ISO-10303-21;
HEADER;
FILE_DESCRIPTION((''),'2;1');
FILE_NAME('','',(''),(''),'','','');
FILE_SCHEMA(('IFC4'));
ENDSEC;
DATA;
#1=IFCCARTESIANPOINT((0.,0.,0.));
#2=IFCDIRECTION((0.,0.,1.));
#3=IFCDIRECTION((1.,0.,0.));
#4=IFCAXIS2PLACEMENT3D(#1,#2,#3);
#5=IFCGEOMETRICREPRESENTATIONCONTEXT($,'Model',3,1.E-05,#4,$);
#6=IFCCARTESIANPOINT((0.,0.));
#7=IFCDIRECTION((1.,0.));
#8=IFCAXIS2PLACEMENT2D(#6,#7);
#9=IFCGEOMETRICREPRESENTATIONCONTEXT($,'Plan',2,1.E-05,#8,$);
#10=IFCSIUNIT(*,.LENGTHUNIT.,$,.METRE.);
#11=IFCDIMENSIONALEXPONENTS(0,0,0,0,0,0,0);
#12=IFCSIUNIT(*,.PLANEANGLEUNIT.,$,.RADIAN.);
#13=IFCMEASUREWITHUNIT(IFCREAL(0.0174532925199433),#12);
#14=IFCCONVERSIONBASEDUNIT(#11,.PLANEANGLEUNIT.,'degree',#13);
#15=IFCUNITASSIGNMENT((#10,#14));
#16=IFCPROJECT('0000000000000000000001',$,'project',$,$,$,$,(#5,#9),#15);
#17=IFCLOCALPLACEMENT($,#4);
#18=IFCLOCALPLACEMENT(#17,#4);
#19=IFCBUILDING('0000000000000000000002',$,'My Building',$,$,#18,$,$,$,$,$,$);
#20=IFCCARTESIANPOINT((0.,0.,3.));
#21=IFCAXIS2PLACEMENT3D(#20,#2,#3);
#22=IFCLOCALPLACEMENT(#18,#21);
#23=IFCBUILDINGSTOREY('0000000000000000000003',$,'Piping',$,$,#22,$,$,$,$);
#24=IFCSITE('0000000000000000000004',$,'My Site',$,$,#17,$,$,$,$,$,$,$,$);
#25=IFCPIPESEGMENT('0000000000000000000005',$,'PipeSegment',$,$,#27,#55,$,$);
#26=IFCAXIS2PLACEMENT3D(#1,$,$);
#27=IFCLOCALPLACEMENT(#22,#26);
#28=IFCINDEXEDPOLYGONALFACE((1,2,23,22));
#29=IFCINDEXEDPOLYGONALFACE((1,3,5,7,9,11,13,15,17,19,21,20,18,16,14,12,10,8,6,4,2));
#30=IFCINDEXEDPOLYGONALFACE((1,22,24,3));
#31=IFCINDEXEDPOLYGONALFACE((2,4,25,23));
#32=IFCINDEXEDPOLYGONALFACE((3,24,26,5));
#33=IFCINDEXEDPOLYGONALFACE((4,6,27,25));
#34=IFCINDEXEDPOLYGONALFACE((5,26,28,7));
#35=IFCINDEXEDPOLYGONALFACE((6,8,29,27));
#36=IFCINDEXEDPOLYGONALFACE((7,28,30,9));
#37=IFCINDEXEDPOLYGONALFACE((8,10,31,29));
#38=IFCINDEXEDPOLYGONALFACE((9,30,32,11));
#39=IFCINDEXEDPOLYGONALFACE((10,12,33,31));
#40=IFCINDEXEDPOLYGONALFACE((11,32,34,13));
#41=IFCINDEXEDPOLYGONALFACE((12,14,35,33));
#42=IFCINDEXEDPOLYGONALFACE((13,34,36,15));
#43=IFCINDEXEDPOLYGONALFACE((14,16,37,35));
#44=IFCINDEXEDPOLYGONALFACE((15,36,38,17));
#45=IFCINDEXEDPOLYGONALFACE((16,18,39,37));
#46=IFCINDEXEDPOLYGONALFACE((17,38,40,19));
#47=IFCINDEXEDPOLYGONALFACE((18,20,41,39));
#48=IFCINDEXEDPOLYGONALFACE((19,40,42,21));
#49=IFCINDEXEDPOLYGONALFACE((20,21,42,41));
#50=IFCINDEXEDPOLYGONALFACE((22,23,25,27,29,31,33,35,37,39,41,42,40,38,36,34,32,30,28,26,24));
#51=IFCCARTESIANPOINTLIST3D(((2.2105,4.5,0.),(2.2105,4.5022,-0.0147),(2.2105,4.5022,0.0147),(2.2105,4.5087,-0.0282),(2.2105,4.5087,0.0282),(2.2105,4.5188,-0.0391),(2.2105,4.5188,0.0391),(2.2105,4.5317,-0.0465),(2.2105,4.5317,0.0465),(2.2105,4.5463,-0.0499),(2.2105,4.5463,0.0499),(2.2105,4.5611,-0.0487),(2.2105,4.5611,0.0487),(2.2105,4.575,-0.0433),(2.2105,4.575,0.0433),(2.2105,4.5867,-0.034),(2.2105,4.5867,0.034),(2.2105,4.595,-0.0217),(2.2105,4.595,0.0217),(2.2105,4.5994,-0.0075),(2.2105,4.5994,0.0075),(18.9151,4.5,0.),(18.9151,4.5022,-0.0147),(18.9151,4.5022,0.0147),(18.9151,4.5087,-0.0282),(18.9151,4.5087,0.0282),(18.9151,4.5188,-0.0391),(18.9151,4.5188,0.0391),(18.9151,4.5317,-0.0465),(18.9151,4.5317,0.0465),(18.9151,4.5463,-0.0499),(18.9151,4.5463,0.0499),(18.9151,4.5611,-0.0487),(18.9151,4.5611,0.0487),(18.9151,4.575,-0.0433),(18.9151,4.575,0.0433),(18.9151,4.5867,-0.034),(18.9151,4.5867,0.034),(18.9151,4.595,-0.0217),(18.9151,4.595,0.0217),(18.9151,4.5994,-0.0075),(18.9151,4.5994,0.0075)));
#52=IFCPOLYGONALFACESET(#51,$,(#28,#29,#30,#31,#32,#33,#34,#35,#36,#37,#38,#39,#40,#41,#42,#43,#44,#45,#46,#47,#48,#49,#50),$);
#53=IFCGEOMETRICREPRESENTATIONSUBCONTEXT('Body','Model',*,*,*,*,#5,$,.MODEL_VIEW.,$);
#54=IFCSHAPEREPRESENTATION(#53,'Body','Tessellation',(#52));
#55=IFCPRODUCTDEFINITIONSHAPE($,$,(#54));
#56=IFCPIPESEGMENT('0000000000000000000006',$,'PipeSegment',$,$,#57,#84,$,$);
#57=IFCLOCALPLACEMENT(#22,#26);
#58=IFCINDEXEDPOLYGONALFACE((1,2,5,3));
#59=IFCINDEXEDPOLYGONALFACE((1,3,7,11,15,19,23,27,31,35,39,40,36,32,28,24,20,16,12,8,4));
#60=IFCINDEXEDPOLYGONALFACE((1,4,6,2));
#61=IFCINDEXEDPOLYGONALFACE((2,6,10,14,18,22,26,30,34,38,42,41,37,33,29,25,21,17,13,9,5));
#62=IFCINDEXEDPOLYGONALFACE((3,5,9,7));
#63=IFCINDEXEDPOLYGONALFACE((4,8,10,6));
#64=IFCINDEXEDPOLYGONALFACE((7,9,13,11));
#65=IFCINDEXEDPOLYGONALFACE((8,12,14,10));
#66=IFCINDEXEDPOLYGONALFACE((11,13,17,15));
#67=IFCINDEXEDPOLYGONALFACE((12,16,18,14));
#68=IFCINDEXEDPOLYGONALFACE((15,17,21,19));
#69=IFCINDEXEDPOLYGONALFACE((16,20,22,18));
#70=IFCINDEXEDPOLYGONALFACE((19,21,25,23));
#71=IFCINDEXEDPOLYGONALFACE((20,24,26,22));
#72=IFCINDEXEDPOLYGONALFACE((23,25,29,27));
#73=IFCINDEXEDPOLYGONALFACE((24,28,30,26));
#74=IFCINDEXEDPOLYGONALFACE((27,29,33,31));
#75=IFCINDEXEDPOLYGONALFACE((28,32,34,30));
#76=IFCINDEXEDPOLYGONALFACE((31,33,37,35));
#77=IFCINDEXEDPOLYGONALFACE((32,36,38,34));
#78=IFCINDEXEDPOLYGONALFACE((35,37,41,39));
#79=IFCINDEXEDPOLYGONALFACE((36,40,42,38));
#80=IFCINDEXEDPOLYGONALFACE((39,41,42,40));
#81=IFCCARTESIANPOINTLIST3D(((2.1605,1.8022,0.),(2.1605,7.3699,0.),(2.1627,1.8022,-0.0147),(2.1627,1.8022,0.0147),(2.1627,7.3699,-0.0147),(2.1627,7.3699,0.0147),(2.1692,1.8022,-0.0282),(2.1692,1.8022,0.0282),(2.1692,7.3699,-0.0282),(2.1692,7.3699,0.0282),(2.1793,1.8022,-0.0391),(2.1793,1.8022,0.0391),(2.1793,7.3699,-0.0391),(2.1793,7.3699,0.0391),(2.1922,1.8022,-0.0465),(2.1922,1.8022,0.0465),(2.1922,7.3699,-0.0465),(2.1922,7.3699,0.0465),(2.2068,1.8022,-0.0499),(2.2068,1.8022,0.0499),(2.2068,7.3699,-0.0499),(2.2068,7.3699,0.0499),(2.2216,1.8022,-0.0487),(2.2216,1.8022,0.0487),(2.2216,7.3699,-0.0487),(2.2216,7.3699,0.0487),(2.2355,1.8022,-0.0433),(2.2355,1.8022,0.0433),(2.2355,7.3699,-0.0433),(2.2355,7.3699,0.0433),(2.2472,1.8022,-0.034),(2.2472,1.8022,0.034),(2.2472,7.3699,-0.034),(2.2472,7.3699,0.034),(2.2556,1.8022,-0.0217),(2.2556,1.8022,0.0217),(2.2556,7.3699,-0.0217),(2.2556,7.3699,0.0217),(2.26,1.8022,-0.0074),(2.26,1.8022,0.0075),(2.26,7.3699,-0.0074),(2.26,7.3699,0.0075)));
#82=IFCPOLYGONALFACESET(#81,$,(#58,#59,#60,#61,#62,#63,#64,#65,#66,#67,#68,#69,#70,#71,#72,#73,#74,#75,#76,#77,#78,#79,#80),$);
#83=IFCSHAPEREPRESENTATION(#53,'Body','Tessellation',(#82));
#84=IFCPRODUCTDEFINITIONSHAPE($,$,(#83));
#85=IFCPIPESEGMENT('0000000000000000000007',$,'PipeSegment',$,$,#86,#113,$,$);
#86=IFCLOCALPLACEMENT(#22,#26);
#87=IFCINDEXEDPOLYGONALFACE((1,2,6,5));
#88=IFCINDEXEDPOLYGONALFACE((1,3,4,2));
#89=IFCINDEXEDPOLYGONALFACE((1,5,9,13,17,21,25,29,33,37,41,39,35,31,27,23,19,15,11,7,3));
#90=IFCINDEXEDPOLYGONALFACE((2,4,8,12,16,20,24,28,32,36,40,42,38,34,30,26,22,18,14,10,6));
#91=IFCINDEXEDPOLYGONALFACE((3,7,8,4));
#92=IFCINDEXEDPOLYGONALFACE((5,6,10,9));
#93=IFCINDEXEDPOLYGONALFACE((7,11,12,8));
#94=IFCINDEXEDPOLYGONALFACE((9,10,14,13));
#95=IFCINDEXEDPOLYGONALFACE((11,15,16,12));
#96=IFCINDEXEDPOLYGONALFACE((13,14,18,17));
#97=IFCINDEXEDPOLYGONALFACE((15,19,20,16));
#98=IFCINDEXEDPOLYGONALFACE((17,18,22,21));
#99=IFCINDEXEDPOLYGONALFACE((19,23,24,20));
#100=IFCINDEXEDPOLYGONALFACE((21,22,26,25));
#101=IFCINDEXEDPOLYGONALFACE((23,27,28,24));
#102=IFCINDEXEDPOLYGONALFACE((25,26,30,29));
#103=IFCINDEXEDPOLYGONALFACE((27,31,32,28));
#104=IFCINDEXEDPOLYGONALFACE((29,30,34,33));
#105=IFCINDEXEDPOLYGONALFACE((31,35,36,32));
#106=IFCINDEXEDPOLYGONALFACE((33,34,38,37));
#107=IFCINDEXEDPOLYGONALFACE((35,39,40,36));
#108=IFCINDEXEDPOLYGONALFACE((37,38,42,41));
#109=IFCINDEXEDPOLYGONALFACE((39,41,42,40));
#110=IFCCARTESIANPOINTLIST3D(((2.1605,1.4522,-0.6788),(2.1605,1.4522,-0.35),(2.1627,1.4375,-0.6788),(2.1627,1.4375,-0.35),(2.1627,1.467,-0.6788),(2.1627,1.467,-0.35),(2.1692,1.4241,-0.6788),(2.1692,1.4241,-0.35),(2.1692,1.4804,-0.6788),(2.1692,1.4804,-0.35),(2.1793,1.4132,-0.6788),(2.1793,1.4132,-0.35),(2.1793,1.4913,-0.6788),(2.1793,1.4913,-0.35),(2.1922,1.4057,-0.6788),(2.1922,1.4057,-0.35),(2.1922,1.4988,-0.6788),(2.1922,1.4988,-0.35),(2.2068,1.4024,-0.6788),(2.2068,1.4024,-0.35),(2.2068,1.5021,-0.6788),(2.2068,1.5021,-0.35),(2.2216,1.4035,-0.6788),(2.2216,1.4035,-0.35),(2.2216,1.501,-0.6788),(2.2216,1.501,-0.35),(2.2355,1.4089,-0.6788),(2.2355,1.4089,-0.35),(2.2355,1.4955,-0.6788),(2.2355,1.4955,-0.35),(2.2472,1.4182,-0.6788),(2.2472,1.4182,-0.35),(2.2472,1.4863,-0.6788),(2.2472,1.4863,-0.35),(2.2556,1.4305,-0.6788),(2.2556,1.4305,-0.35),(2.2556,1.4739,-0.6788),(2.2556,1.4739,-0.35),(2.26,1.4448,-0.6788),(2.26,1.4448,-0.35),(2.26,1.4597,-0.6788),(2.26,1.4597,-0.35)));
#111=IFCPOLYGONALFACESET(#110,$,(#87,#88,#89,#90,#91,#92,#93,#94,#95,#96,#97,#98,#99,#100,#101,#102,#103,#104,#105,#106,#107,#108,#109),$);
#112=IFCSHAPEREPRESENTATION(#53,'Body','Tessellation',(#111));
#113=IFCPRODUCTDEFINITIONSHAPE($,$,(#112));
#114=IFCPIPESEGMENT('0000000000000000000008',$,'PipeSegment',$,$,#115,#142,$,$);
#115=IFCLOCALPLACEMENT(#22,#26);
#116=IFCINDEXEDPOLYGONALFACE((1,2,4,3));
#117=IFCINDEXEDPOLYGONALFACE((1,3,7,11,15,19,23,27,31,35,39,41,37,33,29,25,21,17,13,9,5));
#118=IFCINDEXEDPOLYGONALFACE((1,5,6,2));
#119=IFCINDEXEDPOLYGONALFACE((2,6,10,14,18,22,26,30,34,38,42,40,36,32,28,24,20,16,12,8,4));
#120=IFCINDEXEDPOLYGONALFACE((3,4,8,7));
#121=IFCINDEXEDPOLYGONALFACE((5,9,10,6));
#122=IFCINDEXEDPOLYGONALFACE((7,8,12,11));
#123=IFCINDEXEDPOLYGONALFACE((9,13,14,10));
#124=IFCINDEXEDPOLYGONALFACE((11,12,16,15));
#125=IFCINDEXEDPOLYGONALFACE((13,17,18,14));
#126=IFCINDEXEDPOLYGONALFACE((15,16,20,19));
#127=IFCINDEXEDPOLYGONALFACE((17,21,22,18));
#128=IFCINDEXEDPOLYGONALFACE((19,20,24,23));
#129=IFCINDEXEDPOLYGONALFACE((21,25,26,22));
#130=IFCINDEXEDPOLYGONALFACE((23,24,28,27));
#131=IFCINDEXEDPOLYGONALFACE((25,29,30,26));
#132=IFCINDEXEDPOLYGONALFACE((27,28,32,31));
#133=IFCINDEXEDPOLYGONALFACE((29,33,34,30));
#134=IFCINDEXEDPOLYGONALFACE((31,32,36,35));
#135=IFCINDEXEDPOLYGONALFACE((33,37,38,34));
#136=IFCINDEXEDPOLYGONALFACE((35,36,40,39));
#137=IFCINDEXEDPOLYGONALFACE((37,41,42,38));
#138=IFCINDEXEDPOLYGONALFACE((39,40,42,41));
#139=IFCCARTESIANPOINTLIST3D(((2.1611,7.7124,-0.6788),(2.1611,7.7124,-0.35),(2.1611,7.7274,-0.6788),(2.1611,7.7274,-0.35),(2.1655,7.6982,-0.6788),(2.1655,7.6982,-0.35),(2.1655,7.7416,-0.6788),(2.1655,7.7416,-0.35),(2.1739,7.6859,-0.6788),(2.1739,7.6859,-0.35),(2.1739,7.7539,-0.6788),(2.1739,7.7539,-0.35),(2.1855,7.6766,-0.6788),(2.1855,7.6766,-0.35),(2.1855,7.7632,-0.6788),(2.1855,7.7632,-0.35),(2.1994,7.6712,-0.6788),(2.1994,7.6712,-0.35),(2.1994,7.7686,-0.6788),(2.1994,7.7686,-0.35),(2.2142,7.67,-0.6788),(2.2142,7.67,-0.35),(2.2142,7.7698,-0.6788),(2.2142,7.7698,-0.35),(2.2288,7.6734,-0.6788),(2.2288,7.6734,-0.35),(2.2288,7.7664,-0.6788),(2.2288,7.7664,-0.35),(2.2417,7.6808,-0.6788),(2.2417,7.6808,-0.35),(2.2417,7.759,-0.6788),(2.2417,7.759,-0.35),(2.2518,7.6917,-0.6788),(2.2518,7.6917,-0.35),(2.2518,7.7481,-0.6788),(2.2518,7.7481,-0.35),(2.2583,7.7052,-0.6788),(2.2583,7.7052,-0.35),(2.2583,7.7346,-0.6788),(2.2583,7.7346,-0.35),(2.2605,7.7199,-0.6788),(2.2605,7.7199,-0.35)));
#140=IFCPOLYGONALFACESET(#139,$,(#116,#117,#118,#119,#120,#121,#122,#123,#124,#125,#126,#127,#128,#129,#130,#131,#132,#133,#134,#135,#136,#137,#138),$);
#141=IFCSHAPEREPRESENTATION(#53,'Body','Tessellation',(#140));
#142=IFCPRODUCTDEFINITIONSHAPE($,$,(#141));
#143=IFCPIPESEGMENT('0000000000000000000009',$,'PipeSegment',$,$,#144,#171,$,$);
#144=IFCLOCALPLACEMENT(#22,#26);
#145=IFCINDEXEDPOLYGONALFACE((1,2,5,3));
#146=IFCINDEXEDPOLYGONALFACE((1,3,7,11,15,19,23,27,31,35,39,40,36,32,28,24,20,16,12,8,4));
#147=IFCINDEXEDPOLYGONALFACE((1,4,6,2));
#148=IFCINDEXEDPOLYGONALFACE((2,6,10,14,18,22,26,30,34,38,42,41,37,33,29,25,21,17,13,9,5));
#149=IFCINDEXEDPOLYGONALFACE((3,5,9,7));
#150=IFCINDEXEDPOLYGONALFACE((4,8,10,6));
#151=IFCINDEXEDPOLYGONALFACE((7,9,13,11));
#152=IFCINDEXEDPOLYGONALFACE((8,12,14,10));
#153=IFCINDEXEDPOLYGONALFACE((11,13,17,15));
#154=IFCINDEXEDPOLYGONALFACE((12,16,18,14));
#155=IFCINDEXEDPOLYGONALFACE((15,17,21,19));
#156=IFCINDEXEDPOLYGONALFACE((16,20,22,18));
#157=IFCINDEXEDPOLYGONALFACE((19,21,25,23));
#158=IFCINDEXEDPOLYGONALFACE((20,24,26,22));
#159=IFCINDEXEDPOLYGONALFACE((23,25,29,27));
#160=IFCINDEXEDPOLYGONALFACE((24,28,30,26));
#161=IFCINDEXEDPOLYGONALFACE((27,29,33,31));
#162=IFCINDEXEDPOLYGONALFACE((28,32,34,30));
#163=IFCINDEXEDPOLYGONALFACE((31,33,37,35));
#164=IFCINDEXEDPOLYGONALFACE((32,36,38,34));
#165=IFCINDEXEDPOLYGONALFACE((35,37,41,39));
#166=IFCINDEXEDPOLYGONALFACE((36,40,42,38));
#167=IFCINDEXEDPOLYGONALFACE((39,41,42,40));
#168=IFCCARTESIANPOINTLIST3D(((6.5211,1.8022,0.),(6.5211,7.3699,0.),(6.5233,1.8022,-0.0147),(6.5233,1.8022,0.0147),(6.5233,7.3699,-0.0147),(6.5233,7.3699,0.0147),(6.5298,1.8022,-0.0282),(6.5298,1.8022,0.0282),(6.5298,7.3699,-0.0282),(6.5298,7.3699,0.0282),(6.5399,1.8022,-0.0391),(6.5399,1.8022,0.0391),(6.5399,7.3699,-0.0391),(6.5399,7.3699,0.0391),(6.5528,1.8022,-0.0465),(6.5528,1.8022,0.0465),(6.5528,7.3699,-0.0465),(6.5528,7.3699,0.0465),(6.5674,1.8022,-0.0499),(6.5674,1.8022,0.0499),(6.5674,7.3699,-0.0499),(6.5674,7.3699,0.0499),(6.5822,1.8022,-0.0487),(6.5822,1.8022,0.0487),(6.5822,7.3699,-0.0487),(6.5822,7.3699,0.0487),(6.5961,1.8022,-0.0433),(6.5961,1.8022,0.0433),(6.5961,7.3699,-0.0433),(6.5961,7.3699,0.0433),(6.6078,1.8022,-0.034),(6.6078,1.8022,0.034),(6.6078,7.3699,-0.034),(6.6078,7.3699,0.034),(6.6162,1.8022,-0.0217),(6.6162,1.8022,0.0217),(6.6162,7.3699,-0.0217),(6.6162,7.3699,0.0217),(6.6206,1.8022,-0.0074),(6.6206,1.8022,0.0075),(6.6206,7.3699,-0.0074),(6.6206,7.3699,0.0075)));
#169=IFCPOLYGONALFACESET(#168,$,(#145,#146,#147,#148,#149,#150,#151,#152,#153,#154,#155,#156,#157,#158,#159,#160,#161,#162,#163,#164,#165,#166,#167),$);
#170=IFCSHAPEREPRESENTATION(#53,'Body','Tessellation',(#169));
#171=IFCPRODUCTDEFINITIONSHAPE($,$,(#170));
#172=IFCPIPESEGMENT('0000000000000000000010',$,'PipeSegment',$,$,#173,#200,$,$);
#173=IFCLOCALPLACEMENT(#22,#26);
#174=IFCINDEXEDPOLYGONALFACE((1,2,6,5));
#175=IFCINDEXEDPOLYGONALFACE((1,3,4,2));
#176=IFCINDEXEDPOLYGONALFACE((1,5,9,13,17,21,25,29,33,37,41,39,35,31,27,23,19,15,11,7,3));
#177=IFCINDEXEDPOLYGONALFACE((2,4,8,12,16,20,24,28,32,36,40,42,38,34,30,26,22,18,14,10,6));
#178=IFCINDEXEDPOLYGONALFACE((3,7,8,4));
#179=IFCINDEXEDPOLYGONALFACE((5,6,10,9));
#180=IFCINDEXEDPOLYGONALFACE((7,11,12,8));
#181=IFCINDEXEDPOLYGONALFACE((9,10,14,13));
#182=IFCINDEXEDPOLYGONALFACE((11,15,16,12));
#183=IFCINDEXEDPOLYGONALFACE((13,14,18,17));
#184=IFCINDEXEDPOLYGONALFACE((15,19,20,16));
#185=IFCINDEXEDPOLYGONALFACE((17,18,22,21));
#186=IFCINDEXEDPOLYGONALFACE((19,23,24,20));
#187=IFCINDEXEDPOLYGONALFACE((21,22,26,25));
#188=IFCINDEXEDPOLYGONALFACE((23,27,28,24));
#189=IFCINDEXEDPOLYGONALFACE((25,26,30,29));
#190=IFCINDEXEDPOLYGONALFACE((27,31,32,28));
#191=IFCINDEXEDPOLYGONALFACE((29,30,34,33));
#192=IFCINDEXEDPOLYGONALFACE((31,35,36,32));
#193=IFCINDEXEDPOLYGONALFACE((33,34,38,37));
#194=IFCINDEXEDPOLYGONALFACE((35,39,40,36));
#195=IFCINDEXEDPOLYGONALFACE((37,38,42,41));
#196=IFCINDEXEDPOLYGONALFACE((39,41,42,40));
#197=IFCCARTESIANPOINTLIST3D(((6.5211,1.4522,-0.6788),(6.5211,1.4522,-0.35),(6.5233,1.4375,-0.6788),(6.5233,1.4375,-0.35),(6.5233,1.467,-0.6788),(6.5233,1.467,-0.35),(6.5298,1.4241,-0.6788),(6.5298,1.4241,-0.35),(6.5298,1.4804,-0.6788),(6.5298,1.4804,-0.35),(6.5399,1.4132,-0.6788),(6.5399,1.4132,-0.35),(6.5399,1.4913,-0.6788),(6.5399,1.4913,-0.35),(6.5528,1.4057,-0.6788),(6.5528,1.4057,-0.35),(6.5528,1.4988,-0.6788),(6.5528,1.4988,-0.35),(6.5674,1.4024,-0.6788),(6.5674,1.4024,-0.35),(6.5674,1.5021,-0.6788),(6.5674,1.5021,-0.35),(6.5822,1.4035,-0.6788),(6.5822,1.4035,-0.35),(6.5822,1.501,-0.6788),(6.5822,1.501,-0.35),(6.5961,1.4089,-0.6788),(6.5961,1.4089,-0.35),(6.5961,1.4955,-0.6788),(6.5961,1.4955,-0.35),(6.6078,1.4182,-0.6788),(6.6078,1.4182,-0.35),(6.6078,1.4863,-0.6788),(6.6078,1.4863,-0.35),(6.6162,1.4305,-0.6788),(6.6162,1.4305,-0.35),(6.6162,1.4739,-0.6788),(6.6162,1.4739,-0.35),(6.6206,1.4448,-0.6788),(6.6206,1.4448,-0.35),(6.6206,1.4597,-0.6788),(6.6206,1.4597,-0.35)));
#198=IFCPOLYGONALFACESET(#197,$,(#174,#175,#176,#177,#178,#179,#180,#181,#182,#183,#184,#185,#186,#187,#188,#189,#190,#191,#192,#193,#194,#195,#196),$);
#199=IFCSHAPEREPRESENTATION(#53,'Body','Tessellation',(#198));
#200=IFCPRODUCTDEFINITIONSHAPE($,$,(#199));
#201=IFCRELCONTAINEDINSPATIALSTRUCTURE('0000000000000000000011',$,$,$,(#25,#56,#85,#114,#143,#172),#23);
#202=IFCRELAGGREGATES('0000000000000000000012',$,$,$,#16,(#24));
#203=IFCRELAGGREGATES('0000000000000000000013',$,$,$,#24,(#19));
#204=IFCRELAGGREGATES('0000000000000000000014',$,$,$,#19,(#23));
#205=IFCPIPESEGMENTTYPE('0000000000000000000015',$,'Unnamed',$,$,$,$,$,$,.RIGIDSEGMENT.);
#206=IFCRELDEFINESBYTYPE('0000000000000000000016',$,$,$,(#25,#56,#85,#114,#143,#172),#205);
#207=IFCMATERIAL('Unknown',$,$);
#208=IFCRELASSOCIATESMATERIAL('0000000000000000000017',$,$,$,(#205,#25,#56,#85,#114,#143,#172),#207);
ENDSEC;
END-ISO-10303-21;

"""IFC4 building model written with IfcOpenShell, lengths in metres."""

from ifc_helpers import new_model, entity, si_unit, converted_unit, frame, origin_with_axes, origin_2d_with_axis, place, context, subcontext, project, spatial, circle, extrude, material, material_profile, profile_set, profile_usage, type_object, element, save


model = new_model("IFC4")

# Units and contexts
model_context = context("Model", 3, precision=1e-05, world=origin_with_axes())
plan_context = context("Plan", 2, precision=1e-05, world=origin_2d_with_axis())
body_context = subcontext(model_context, "Body", "Model", "MODEL_VIEW")
ifc_project = project(units=[si_unit("LENGTHUNIT", "METRE"), converted_unit("PLANEANGLEUNIT", "degree", entity("IfcReal", 0.0174532925199433), si_unit("PLANEANGLEUNIT", "RADIAN"), dimensions=[0, 0, 0, 0, 0, 0, 0])], contexts=[model_context, plan_context])

# Site, building, storey
site_placement = place(None, origin_with_axes())
site = spatial("IfcSite", under=ifc_project, at=site_placement, Name="My Site")
building_placement = place(site_placement, origin_with_axes())
building = spatial("IfcBuilding", under=site, at=building_placement, Name="My Building")
storey_placement = place(building_placement, frame((0.0, 0.0, 3.0), z_axis=(0.0, 0.0, 1.0), x_axis=(1.0, 0.0, 0.0)))
storey = spatial("IfcBuildingStorey", under=building, at=storey_placement, Name="Piping")

# Pipe segments
ifc_material = material(Name="Unknown")
ifc_material_profile = material_profile(ifc_material, circle(Radius=0.05))
ifc_profile_set = profile_set([ifc_material_profile])
ifc_profile_usage_1 = profile_usage(ifc_profile_set, cardinal=5)
pipe_segment_type = type_object("IfcPipeSegmentType", Name="Unnamed", PredefinedType="RIGIDSEGMENT", material=ifc_profile_set)
pipe_segment_1_placement = place(storey_placement, frame((18.9151, 4.55, 0.0), z_axis=(-1.0, 0.0, 0.0), x_axis=(0.0, -1.0, 0.0)))
element("IfcPipeSegment", 1, at=pipe_segment_1_placement, inside=storey, type_object=pipe_segment_type, material=ifc_profile_usage_1, Name="PipeSegment", context=body_context, shape_type="SweptSolid", body=[
    extrude(circle(Radius=0.05), origin_with_axes(), (0.0, 0.0, 1.0), 16.7046),
])
ifc_profile_usage_2 = profile_usage(ifc_profile_set, cardinal=5)
pipe_segment_2_placement = place(storey_placement, frame((2.2105, 1.8022, 0.0), z_axis=(0.0, 1.0, 0.0), x_axis=(-1.0, 0.0, 0.0)))
element("IfcPipeSegment", 2, at=pipe_segment_2_placement, inside=storey, type_object=pipe_segment_type, material=ifc_profile_usage_2, Name="PipeSegment", context=body_context, shape_type="SweptSolid", body=[
    extrude(circle(Radius=0.05), origin_with_axes(), (0.0, 0.0, 1.0), 5.5677),
])
ifc_profile_usage_3 = profile_usage(ifc_profile_set, cardinal=5)
pipe_segment_3_placement = place(storey_placement, frame((2.2105, 1.4522, -0.35), z_axis=(0.0, 0.0, -1.0), x_axis=(-1.0, 0.0, 0.0)))
element("IfcPipeSegment", 3, at=pipe_segment_3_placement, inside=storey, type_object=pipe_segment_type, material=ifc_profile_usage_3, Name="PipeSegment", context=body_context, shape_type="SweptSolid", body=[
    extrude(circle(Radius=0.05), origin_with_axes(), (0.0, 0.0, 1.0), 0.3288),
])
ifc_profile_usage_4 = profile_usage(ifc_profile_set, cardinal=5)
pipe_segment_4_placement = place(storey_placement, frame((2.2105, 7.7199, -0.6788), z_axis=(0.0, 0.0, 1.0), x_axis=(1.0, 0.0, 0.0)))
element("IfcPipeSegment", 4, at=pipe_segment_4_placement, inside=storey, type_object=pipe_segment_type, material=ifc_profile_usage_4, Name="PipeSegment", context=body_context, shape_type="SweptSolid", body=[
    extrude(circle(Radius=0.05), origin_with_axes(), (0.0, 0.0, 1.0), 0.3288),
])
ifc_profile_usage_5 = profile_usage(ifc_profile_set, cardinal=5)
pipe_segment_5_placement = place(storey_placement, frame((6.5711, 1.8022, 0.0), z_axis=(0.0, 1.0, 0.0), x_axis=(-1.0, 0.0, 0.0)))
element("IfcPipeSegment", 5, at=pipe_segment_5_placement, inside=storey, type_object=pipe_segment_type, material=ifc_profile_usage_5, Name="PipeSegment", context=body_context, shape_type="SweptSolid", body=[
    extrude(circle(Radius=0.05), origin_with_axes(), (0.0, 0.0, 1.0), 5.5677),
])
ifc_profile_usage_6 = profile_usage(ifc_profile_set, cardinal=5)
pipe_segment_6_placement = place(storey_placement, frame((6.5711, 1.4522, -0.35), z_axis=(0.0, 0.0, -1.0), x_axis=(-1.0, 0.0, 0.0)))
element("IfcPipeSegment", 6, at=pipe_segment_6_placement, inside=storey, type_object=pipe_segment_type, material=ifc_profile_usage_6, Name="PipeSegment", context=body_context, shape_type="SweptSolid", body=[
    extrude(circle(Radius=0.05), origin_with_axes(), (0.0, 0.0, 1.0), 0.3288),
])

save(model, "model.ifc")
